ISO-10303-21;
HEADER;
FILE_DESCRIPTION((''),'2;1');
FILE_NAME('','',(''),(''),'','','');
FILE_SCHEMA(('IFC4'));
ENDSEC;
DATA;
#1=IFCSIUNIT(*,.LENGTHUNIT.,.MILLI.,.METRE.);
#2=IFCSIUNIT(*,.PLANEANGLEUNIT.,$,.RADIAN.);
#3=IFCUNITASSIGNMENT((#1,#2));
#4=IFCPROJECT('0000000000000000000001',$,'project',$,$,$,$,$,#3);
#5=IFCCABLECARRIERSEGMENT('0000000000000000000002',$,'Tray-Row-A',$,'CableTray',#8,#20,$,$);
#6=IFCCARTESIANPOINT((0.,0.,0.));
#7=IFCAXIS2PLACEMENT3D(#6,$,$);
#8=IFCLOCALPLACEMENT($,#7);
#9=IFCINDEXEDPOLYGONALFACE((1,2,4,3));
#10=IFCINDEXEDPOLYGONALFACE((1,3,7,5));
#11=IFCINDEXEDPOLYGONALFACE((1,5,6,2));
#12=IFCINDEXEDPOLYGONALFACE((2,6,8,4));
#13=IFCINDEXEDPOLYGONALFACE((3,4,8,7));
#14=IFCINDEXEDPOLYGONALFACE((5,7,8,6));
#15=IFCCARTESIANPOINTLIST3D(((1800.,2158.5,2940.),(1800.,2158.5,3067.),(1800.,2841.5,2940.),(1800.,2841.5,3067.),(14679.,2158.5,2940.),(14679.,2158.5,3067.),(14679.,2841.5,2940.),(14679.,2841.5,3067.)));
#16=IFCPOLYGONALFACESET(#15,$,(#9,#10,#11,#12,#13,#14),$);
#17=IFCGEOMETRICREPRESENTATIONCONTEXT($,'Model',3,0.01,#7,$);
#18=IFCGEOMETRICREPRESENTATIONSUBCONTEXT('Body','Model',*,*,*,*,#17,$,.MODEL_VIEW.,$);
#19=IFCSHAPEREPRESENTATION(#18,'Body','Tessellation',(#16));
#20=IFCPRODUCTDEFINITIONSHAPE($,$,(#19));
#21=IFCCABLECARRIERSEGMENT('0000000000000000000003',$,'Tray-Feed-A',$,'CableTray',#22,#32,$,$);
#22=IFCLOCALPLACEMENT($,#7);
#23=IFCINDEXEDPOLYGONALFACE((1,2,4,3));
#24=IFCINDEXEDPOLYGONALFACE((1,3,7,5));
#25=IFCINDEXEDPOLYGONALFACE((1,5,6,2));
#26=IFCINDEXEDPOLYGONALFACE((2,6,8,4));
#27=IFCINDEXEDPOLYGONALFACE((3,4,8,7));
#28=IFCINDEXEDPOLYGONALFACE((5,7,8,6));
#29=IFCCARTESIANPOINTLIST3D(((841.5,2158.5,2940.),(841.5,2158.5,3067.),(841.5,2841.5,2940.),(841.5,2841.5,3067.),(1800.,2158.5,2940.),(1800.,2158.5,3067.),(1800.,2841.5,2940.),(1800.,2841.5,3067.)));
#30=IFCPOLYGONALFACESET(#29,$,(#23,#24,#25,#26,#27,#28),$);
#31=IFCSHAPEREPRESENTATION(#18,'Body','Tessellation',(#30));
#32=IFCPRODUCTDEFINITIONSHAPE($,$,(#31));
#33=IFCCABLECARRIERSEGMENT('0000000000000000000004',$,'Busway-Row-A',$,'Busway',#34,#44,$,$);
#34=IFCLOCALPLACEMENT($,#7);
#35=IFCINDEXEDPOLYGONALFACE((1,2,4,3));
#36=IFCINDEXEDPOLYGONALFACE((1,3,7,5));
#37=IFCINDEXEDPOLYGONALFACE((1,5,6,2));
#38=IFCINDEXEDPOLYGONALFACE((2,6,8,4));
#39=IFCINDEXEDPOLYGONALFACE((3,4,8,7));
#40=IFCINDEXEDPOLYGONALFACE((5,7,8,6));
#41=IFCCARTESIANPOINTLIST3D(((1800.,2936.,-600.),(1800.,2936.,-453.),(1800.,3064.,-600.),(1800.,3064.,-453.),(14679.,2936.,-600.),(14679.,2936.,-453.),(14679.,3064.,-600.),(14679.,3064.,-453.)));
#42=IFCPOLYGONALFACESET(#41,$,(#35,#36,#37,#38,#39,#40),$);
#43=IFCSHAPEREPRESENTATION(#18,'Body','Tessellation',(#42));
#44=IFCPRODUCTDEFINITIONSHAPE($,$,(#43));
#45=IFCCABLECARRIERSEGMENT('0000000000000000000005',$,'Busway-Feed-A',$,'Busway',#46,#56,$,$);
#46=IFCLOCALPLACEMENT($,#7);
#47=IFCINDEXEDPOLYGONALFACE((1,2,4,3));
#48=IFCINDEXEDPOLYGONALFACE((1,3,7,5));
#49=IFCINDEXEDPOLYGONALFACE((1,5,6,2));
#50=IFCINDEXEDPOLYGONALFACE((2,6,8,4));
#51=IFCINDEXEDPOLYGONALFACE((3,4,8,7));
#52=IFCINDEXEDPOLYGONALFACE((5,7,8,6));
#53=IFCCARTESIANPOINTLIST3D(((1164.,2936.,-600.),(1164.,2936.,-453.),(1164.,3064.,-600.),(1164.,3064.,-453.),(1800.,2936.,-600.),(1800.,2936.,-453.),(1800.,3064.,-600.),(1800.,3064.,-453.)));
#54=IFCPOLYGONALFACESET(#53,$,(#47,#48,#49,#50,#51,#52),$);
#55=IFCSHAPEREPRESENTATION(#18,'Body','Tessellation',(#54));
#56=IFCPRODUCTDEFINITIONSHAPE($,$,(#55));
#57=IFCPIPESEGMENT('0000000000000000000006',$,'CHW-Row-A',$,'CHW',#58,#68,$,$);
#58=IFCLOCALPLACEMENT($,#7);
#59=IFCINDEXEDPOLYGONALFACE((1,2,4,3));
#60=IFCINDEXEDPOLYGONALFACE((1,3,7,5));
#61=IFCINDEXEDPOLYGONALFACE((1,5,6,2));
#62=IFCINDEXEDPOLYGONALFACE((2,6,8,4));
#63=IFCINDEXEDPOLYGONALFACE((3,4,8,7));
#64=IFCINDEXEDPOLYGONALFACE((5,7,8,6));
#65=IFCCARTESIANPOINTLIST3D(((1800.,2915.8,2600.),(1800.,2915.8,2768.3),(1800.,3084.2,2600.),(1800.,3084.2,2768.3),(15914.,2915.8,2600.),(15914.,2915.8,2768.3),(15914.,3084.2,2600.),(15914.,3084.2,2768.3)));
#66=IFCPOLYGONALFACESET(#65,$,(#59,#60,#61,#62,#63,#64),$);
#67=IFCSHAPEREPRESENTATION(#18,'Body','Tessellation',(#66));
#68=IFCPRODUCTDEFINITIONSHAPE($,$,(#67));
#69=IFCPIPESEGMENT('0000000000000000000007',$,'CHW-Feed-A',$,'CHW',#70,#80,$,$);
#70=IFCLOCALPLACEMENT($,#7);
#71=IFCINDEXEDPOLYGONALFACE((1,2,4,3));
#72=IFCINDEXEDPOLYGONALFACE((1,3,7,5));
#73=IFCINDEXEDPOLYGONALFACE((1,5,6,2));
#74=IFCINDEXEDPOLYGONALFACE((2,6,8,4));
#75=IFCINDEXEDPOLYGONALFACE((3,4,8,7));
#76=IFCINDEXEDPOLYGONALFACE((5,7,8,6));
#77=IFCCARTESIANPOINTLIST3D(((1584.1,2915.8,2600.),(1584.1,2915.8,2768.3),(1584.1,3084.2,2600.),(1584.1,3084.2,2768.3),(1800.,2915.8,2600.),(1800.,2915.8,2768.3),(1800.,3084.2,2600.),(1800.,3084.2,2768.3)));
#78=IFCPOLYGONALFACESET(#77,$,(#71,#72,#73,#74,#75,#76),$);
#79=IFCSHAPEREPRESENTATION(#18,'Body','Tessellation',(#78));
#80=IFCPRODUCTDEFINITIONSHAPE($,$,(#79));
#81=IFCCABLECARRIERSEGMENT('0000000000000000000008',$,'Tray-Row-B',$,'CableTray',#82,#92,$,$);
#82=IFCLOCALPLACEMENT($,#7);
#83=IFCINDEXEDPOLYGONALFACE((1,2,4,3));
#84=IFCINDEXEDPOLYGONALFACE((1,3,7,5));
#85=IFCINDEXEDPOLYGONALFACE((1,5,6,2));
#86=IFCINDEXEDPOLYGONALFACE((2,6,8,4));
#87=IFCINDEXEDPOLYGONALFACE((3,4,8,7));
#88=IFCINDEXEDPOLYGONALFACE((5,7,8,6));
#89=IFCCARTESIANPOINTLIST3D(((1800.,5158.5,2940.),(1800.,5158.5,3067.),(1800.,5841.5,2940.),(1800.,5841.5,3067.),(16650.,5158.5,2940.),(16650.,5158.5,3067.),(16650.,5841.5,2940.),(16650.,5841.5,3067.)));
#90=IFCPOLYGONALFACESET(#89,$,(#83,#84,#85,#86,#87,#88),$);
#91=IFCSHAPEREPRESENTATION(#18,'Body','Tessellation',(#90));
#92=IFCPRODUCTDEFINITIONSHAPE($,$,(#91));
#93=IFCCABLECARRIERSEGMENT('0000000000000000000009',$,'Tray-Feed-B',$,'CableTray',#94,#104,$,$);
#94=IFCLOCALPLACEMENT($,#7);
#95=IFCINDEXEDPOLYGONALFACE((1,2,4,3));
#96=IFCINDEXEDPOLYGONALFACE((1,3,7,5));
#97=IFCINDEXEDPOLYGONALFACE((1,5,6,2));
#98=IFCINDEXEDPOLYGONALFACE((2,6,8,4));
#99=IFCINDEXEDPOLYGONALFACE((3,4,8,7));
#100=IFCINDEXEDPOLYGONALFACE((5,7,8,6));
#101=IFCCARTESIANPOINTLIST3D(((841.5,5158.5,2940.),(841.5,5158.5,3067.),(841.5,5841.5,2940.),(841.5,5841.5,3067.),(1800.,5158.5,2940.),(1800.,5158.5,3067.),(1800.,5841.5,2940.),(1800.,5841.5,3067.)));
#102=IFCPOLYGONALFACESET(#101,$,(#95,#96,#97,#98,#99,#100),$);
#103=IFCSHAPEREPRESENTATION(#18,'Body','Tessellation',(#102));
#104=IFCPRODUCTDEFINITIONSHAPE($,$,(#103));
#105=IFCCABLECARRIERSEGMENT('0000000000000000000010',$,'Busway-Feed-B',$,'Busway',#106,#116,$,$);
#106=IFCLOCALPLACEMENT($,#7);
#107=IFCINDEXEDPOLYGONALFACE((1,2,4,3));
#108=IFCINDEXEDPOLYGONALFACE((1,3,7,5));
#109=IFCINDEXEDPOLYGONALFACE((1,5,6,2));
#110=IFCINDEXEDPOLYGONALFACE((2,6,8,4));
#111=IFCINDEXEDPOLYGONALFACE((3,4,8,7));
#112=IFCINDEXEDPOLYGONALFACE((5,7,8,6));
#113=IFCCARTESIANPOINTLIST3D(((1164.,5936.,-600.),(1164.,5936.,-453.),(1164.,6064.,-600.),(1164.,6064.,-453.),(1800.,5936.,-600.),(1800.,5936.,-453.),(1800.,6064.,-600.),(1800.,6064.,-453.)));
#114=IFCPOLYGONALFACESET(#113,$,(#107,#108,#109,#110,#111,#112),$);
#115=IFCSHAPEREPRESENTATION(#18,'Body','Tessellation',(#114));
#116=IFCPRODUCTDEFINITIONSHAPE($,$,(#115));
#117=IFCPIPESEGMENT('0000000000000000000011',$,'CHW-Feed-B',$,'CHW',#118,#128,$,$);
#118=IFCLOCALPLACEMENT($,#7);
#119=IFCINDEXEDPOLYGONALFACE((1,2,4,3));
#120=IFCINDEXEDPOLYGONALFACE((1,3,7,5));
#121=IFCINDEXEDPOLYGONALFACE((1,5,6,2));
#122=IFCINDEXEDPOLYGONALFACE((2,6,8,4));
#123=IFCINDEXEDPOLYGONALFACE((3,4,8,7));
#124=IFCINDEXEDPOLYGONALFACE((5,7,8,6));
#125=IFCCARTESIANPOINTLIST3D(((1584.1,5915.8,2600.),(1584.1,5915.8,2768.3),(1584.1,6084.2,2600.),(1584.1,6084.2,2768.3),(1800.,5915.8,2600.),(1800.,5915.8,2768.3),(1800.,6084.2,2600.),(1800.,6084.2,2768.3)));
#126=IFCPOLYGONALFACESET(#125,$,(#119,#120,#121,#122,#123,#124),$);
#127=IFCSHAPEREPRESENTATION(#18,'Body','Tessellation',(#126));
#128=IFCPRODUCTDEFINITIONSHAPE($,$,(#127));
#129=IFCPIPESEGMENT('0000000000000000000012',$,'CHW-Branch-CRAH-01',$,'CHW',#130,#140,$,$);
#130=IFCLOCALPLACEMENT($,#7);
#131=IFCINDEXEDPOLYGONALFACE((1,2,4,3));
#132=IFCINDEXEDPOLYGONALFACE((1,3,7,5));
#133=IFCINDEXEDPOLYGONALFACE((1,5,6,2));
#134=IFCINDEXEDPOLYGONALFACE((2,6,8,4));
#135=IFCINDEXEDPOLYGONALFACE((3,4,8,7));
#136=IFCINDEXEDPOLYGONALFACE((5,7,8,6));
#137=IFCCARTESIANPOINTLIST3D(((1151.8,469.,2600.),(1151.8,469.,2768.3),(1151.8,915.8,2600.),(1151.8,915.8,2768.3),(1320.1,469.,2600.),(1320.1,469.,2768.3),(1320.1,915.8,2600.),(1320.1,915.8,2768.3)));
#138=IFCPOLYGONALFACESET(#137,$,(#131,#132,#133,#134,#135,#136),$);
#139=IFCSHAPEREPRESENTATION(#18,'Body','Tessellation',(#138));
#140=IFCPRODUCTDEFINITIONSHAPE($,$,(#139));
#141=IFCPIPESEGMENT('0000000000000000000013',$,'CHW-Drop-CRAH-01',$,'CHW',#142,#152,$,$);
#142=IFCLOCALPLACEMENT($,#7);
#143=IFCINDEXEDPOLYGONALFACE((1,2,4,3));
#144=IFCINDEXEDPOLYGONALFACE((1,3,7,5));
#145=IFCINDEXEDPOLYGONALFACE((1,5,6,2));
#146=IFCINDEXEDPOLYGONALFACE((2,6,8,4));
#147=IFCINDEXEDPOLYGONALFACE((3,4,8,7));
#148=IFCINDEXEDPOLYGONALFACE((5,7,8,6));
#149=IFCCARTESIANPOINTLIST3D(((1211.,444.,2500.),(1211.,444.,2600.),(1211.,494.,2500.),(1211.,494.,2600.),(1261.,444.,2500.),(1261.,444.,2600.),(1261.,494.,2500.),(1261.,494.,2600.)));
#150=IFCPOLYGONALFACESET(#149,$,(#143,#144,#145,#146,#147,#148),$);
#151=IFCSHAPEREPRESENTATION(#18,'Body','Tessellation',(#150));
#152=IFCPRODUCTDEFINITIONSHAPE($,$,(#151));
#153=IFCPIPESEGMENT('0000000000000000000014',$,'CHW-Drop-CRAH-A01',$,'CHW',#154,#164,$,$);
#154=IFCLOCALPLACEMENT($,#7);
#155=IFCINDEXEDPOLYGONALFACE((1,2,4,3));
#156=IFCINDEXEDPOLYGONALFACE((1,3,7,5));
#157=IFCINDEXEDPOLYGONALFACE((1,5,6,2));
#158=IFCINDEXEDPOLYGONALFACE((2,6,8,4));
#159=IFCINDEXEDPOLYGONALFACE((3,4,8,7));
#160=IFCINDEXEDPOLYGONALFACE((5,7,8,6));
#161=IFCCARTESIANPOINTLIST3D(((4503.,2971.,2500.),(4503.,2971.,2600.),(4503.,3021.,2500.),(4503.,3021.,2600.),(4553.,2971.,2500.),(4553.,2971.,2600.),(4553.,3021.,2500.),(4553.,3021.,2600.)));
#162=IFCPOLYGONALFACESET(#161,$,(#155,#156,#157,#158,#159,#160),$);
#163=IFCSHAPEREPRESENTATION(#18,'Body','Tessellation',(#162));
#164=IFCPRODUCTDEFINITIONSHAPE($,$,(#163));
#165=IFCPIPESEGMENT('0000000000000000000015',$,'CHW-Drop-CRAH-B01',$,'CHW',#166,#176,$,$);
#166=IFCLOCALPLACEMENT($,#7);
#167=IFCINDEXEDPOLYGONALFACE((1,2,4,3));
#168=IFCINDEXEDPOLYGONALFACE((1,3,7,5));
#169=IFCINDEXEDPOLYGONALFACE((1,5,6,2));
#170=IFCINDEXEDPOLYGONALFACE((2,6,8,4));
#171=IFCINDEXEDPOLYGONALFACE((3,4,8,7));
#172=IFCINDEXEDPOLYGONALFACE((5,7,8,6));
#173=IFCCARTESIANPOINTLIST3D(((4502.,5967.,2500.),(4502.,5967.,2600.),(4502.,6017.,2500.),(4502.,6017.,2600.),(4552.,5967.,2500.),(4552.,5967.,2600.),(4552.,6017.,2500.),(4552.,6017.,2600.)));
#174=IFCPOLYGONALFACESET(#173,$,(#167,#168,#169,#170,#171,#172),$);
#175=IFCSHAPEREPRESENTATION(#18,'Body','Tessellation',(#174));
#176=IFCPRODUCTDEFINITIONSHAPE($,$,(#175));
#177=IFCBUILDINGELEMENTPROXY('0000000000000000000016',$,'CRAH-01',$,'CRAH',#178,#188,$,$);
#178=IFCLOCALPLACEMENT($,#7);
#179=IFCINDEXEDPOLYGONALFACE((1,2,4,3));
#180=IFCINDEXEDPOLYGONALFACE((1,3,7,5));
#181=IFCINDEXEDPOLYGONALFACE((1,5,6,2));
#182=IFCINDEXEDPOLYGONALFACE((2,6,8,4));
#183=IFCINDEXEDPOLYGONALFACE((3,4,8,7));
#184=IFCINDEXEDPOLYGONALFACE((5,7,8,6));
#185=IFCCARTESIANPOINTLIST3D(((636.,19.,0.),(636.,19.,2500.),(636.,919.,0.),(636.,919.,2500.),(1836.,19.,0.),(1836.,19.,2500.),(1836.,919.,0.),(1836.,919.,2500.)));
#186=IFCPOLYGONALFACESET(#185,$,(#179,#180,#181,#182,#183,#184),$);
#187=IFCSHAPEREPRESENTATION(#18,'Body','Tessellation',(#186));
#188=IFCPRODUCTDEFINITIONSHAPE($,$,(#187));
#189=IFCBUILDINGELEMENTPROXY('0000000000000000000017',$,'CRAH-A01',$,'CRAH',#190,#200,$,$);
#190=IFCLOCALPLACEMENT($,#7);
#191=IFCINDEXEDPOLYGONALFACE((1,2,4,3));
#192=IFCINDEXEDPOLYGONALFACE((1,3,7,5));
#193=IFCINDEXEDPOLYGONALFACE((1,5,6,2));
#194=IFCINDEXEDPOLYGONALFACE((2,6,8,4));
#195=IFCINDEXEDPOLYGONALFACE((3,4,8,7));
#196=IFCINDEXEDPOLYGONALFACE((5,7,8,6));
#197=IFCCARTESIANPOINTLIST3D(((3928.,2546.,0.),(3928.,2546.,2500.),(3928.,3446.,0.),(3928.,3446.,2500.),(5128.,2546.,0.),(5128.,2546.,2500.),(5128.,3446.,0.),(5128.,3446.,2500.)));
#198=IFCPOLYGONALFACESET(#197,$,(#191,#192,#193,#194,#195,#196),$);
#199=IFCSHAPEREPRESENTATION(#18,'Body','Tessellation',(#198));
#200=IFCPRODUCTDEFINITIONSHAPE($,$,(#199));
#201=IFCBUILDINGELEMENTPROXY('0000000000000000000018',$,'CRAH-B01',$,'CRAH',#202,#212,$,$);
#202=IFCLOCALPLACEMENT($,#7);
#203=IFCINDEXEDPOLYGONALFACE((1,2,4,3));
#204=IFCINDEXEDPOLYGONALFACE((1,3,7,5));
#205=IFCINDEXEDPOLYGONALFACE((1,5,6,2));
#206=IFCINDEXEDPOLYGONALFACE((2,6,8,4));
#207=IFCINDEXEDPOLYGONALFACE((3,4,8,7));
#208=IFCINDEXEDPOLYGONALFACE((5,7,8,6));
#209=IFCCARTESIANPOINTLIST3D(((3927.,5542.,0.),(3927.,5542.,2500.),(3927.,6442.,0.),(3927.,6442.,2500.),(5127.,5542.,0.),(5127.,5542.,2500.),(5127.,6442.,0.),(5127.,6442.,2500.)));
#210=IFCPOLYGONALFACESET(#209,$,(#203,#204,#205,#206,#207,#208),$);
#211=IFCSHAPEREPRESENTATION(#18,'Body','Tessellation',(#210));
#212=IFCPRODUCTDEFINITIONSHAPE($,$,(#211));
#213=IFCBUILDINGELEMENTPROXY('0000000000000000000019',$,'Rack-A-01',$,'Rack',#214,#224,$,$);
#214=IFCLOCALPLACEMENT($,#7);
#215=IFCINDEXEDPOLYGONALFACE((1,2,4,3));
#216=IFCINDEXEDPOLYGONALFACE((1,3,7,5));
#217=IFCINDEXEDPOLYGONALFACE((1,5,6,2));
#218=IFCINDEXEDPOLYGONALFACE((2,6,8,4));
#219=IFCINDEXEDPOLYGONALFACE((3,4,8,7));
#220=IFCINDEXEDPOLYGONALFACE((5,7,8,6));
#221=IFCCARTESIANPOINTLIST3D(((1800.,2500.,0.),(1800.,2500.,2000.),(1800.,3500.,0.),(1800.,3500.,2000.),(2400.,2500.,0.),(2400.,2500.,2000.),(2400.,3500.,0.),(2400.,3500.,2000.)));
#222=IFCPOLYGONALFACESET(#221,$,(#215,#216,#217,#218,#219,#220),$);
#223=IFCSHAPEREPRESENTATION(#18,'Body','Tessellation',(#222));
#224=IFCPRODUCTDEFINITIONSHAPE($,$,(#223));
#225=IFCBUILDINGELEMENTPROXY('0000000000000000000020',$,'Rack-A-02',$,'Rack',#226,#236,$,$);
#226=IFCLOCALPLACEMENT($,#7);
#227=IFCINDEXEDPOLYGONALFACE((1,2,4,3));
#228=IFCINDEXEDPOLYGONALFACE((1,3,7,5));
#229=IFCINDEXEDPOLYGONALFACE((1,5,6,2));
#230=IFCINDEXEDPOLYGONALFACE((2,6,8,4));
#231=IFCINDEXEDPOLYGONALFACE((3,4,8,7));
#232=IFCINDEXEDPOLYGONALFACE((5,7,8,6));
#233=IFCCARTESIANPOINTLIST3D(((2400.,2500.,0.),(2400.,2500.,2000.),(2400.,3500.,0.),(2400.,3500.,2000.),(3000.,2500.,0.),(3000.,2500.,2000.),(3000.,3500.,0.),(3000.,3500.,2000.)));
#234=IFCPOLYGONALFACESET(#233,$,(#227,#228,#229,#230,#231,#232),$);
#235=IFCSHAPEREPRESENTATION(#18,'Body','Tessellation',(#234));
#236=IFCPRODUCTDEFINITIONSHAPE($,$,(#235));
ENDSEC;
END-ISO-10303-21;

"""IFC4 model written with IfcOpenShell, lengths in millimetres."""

from ifc_helpers import new_model, si_unit, frame, origin, place, context, subcontext, project, rectangle, extrude, element, save


model = new_model("IFC4")

# Units and contexts
model_context = context("Model", 3, precision=0.01, world=origin())
body_context = subcontext(model_context, "Body", "Model", "MODEL_VIEW")
ifc_project = project(units=[si_unit("LENGTHUNIT", "METRE", prefix="MILLI"), si_unit("PLANEANGLEUNIT", "RADIAN")])

# Cable carrier segments
placement = place(None, origin())
cable_carrier_segment_1_placement = place(placement, frame((8239.5, 2500.0, 2940.0)))
element("IfcCableCarrierSegment", 1, at=cable_carrier_segment_1_placement, Name="Tray-Row-A", ObjectType="CableTray", context=body_context, shape_type="SweptSolid", body=[
    extrude(rectangle(XDim=12879.0, YDim=683.0), origin(), (0.0, 0.0, 1.0), 127.0),
])
cable_carrier_segment_2_placement = place(placement, frame((1320.8, 2500.0, 2940.0)))
element("IfcCableCarrierSegment", 2, at=cable_carrier_segment_2_placement, Name="Tray-Feed-A", ObjectType="CableTray", context=body_context, shape_type="SweptSolid", body=[
    extrude(rectangle(XDim=958.5, YDim=683.0), origin(), (0.0, 0.0, 1.0), 127.0),
])
cable_carrier_segment_3_placement = place(placement, frame((8239.5, 3000.0, -600.0)))
element("IfcCableCarrierSegment", 3, at=cable_carrier_segment_3_placement, Name="Busway-Row-A", ObjectType="Busway", context=body_context, shape_type="SweptSolid", body=[
    extrude(rectangle(XDim=12879.0, YDim=128.0), origin(), (0.0, 0.0, 1.0), 147.0),
])
cable_carrier_segment_4_placement = place(placement, frame((1482.0, 3000.0, -600.0)))
element("IfcCableCarrierSegment", 4, at=cable_carrier_segment_4_placement, Name="Busway-Feed-A", ObjectType="Busway", context=body_context, shape_type="SweptSolid", body=[
    extrude(rectangle(XDim=636.0, YDim=128.0), origin(), (0.0, 0.0, 1.0), 147.0),
])

# Pipe segments
pipe_segment_1_placement = place(placement, frame((8857.0, 3000.0, 2600.0)))
element("IfcPipeSegment", 5, at=pipe_segment_1_placement, Name="CHW-Row-A", ObjectType="CHW", context=body_context, shape_type="SweptSolid", body=[
    extrude(rectangle(XDim=14114.0, YDim=168.3), origin(), (0.0, 0.0, 1.0), 168.3),
])
pipe_segment_2_placement = place(placement, frame((1692.1, 3000.0, 2600.0)))
element("IfcPipeSegment", 6, at=pipe_segment_2_placement, Name="CHW-Feed-A", ObjectType="CHW", context=body_context, shape_type="SweptSolid", body=[
    extrude(rectangle(XDim=215.8, YDim=168.3), origin(), (0.0, 0.0, 1.0), 168.3),
])

# Cable carrier segments
cable_carrier_segment_5_placement = place(placement, frame((9225.0, 5500.0, 2940.0)))
element("IfcCableCarrierSegment", 7, at=cable_carrier_segment_5_placement, Name="Tray-Row-B", ObjectType="CableTray", context=body_context, shape_type="SweptSolid", body=[
    extrude(rectangle(XDim=14850.0, YDim=683.0), origin(), (0.0, 0.0, 1.0), 127.0),
])
cable_carrier_segment_6_placement = place(placement, frame((1320.8, 5500.0, 2940.0)))
element("IfcCableCarrierSegment", 8, at=cable_carrier_segment_6_placement, Name="Tray-Feed-B", ObjectType="CableTray", context=body_context, shape_type="SweptSolid", body=[
    extrude(rectangle(XDim=958.5, YDim=683.0), origin(), (0.0, 0.0, 1.0), 127.0),
])
cable_carrier_segment_7_placement = place(placement, frame((1482.0, 6000.0, -600.0)))
element("IfcCableCarrierSegment", 9, at=cable_carrier_segment_7_placement, Name="Busway-Feed-B", ObjectType="Busway", context=body_context, shape_type="SweptSolid", body=[
    extrude(rectangle(XDim=636.0, YDim=128.0), origin(), (0.0, 0.0, 1.0), 147.0),
])

# Pipe segments
pipe_segment_3_placement = place(placement, frame((1692.1, 6000.0, 2600.0)))
element("IfcPipeSegment", 10, at=pipe_segment_3_placement, Name="CHW-Feed-B", ObjectType="CHW", context=body_context, shape_type="SweptSolid", body=[
    extrude(rectangle(XDim=215.8, YDim=168.3), origin(), (0.0, 0.0, 1.0), 168.3),
])
pipe_segment_4_placement = place(placement, frame((1236.0, 692.4, 2600.0)))
element("IfcPipeSegment", 11, at=pipe_segment_4_placement, Name="CHW-Branch-CRAH-01", ObjectType="CHW", context=body_context, shape_type="SweptSolid", body=[
    extrude(rectangle(XDim=168.3, YDim=446.9), origin(), (0.0, 0.0, 1.0), 168.3),
])
for number, where, name in (
    (12, (1236.0, 469.0, 2500.0), "CHW-Drop-CRAH-01"),
    (13, (4528.0, 2996.0, 2500.0), "CHW-Drop-CRAH-A01"),
    (14, (4527.0, 5992.0, 2500.0), "CHW-Drop-CRAH-B01"),
):
    element("IfcPipeSegment", number, at=place(placement, frame(where)), Name=name, ObjectType="CHW", context=body_context, shape_type="SweptSolid", body=[
        extrude(rectangle(XDim=50.0, YDim=50.0), origin(), (0.0, 0.0, 1.0), 100.0),
    ])

# Building element proxies
for number, where, name in (
    (15, (1236.0, 469.0, 0.0), "CRAH-01"),
    (16, (4528.0, 2996.0, 0.0), "CRAH-A01"),
    (17, (4527.0, 5992.0, 0.0), "CRAH-B01"),
):
    element("IfcBuildingElementProxy", number, at=place(placement, frame(where)), Name=name, ObjectType="CRAH", context=body_context, shape_type="SweptSolid", body=[
        extrude(rectangle(XDim=1200.0, YDim=900.0), origin(), (0.0, 0.0, 1.0), 2500.0),
    ])
for number, where, name in (
    (18, (2100.0, 3000.0, 0.0), "Rack-A-01"),
    (19, (2700.0, 3000.0, 0.0), "Rack-A-02"),
):
    element("IfcBuildingElementProxy", number, at=place(placement, frame(where)), Name=name, ObjectType="Rack", context=body_context, shape_type="SweptSolid", body=[
        extrude(rectangle(XDim=600.0, YDim=1000.0), origin(), (0.0, 0.0, 1.0), 2000.0),
    ])

save(model, "model.ifc")
